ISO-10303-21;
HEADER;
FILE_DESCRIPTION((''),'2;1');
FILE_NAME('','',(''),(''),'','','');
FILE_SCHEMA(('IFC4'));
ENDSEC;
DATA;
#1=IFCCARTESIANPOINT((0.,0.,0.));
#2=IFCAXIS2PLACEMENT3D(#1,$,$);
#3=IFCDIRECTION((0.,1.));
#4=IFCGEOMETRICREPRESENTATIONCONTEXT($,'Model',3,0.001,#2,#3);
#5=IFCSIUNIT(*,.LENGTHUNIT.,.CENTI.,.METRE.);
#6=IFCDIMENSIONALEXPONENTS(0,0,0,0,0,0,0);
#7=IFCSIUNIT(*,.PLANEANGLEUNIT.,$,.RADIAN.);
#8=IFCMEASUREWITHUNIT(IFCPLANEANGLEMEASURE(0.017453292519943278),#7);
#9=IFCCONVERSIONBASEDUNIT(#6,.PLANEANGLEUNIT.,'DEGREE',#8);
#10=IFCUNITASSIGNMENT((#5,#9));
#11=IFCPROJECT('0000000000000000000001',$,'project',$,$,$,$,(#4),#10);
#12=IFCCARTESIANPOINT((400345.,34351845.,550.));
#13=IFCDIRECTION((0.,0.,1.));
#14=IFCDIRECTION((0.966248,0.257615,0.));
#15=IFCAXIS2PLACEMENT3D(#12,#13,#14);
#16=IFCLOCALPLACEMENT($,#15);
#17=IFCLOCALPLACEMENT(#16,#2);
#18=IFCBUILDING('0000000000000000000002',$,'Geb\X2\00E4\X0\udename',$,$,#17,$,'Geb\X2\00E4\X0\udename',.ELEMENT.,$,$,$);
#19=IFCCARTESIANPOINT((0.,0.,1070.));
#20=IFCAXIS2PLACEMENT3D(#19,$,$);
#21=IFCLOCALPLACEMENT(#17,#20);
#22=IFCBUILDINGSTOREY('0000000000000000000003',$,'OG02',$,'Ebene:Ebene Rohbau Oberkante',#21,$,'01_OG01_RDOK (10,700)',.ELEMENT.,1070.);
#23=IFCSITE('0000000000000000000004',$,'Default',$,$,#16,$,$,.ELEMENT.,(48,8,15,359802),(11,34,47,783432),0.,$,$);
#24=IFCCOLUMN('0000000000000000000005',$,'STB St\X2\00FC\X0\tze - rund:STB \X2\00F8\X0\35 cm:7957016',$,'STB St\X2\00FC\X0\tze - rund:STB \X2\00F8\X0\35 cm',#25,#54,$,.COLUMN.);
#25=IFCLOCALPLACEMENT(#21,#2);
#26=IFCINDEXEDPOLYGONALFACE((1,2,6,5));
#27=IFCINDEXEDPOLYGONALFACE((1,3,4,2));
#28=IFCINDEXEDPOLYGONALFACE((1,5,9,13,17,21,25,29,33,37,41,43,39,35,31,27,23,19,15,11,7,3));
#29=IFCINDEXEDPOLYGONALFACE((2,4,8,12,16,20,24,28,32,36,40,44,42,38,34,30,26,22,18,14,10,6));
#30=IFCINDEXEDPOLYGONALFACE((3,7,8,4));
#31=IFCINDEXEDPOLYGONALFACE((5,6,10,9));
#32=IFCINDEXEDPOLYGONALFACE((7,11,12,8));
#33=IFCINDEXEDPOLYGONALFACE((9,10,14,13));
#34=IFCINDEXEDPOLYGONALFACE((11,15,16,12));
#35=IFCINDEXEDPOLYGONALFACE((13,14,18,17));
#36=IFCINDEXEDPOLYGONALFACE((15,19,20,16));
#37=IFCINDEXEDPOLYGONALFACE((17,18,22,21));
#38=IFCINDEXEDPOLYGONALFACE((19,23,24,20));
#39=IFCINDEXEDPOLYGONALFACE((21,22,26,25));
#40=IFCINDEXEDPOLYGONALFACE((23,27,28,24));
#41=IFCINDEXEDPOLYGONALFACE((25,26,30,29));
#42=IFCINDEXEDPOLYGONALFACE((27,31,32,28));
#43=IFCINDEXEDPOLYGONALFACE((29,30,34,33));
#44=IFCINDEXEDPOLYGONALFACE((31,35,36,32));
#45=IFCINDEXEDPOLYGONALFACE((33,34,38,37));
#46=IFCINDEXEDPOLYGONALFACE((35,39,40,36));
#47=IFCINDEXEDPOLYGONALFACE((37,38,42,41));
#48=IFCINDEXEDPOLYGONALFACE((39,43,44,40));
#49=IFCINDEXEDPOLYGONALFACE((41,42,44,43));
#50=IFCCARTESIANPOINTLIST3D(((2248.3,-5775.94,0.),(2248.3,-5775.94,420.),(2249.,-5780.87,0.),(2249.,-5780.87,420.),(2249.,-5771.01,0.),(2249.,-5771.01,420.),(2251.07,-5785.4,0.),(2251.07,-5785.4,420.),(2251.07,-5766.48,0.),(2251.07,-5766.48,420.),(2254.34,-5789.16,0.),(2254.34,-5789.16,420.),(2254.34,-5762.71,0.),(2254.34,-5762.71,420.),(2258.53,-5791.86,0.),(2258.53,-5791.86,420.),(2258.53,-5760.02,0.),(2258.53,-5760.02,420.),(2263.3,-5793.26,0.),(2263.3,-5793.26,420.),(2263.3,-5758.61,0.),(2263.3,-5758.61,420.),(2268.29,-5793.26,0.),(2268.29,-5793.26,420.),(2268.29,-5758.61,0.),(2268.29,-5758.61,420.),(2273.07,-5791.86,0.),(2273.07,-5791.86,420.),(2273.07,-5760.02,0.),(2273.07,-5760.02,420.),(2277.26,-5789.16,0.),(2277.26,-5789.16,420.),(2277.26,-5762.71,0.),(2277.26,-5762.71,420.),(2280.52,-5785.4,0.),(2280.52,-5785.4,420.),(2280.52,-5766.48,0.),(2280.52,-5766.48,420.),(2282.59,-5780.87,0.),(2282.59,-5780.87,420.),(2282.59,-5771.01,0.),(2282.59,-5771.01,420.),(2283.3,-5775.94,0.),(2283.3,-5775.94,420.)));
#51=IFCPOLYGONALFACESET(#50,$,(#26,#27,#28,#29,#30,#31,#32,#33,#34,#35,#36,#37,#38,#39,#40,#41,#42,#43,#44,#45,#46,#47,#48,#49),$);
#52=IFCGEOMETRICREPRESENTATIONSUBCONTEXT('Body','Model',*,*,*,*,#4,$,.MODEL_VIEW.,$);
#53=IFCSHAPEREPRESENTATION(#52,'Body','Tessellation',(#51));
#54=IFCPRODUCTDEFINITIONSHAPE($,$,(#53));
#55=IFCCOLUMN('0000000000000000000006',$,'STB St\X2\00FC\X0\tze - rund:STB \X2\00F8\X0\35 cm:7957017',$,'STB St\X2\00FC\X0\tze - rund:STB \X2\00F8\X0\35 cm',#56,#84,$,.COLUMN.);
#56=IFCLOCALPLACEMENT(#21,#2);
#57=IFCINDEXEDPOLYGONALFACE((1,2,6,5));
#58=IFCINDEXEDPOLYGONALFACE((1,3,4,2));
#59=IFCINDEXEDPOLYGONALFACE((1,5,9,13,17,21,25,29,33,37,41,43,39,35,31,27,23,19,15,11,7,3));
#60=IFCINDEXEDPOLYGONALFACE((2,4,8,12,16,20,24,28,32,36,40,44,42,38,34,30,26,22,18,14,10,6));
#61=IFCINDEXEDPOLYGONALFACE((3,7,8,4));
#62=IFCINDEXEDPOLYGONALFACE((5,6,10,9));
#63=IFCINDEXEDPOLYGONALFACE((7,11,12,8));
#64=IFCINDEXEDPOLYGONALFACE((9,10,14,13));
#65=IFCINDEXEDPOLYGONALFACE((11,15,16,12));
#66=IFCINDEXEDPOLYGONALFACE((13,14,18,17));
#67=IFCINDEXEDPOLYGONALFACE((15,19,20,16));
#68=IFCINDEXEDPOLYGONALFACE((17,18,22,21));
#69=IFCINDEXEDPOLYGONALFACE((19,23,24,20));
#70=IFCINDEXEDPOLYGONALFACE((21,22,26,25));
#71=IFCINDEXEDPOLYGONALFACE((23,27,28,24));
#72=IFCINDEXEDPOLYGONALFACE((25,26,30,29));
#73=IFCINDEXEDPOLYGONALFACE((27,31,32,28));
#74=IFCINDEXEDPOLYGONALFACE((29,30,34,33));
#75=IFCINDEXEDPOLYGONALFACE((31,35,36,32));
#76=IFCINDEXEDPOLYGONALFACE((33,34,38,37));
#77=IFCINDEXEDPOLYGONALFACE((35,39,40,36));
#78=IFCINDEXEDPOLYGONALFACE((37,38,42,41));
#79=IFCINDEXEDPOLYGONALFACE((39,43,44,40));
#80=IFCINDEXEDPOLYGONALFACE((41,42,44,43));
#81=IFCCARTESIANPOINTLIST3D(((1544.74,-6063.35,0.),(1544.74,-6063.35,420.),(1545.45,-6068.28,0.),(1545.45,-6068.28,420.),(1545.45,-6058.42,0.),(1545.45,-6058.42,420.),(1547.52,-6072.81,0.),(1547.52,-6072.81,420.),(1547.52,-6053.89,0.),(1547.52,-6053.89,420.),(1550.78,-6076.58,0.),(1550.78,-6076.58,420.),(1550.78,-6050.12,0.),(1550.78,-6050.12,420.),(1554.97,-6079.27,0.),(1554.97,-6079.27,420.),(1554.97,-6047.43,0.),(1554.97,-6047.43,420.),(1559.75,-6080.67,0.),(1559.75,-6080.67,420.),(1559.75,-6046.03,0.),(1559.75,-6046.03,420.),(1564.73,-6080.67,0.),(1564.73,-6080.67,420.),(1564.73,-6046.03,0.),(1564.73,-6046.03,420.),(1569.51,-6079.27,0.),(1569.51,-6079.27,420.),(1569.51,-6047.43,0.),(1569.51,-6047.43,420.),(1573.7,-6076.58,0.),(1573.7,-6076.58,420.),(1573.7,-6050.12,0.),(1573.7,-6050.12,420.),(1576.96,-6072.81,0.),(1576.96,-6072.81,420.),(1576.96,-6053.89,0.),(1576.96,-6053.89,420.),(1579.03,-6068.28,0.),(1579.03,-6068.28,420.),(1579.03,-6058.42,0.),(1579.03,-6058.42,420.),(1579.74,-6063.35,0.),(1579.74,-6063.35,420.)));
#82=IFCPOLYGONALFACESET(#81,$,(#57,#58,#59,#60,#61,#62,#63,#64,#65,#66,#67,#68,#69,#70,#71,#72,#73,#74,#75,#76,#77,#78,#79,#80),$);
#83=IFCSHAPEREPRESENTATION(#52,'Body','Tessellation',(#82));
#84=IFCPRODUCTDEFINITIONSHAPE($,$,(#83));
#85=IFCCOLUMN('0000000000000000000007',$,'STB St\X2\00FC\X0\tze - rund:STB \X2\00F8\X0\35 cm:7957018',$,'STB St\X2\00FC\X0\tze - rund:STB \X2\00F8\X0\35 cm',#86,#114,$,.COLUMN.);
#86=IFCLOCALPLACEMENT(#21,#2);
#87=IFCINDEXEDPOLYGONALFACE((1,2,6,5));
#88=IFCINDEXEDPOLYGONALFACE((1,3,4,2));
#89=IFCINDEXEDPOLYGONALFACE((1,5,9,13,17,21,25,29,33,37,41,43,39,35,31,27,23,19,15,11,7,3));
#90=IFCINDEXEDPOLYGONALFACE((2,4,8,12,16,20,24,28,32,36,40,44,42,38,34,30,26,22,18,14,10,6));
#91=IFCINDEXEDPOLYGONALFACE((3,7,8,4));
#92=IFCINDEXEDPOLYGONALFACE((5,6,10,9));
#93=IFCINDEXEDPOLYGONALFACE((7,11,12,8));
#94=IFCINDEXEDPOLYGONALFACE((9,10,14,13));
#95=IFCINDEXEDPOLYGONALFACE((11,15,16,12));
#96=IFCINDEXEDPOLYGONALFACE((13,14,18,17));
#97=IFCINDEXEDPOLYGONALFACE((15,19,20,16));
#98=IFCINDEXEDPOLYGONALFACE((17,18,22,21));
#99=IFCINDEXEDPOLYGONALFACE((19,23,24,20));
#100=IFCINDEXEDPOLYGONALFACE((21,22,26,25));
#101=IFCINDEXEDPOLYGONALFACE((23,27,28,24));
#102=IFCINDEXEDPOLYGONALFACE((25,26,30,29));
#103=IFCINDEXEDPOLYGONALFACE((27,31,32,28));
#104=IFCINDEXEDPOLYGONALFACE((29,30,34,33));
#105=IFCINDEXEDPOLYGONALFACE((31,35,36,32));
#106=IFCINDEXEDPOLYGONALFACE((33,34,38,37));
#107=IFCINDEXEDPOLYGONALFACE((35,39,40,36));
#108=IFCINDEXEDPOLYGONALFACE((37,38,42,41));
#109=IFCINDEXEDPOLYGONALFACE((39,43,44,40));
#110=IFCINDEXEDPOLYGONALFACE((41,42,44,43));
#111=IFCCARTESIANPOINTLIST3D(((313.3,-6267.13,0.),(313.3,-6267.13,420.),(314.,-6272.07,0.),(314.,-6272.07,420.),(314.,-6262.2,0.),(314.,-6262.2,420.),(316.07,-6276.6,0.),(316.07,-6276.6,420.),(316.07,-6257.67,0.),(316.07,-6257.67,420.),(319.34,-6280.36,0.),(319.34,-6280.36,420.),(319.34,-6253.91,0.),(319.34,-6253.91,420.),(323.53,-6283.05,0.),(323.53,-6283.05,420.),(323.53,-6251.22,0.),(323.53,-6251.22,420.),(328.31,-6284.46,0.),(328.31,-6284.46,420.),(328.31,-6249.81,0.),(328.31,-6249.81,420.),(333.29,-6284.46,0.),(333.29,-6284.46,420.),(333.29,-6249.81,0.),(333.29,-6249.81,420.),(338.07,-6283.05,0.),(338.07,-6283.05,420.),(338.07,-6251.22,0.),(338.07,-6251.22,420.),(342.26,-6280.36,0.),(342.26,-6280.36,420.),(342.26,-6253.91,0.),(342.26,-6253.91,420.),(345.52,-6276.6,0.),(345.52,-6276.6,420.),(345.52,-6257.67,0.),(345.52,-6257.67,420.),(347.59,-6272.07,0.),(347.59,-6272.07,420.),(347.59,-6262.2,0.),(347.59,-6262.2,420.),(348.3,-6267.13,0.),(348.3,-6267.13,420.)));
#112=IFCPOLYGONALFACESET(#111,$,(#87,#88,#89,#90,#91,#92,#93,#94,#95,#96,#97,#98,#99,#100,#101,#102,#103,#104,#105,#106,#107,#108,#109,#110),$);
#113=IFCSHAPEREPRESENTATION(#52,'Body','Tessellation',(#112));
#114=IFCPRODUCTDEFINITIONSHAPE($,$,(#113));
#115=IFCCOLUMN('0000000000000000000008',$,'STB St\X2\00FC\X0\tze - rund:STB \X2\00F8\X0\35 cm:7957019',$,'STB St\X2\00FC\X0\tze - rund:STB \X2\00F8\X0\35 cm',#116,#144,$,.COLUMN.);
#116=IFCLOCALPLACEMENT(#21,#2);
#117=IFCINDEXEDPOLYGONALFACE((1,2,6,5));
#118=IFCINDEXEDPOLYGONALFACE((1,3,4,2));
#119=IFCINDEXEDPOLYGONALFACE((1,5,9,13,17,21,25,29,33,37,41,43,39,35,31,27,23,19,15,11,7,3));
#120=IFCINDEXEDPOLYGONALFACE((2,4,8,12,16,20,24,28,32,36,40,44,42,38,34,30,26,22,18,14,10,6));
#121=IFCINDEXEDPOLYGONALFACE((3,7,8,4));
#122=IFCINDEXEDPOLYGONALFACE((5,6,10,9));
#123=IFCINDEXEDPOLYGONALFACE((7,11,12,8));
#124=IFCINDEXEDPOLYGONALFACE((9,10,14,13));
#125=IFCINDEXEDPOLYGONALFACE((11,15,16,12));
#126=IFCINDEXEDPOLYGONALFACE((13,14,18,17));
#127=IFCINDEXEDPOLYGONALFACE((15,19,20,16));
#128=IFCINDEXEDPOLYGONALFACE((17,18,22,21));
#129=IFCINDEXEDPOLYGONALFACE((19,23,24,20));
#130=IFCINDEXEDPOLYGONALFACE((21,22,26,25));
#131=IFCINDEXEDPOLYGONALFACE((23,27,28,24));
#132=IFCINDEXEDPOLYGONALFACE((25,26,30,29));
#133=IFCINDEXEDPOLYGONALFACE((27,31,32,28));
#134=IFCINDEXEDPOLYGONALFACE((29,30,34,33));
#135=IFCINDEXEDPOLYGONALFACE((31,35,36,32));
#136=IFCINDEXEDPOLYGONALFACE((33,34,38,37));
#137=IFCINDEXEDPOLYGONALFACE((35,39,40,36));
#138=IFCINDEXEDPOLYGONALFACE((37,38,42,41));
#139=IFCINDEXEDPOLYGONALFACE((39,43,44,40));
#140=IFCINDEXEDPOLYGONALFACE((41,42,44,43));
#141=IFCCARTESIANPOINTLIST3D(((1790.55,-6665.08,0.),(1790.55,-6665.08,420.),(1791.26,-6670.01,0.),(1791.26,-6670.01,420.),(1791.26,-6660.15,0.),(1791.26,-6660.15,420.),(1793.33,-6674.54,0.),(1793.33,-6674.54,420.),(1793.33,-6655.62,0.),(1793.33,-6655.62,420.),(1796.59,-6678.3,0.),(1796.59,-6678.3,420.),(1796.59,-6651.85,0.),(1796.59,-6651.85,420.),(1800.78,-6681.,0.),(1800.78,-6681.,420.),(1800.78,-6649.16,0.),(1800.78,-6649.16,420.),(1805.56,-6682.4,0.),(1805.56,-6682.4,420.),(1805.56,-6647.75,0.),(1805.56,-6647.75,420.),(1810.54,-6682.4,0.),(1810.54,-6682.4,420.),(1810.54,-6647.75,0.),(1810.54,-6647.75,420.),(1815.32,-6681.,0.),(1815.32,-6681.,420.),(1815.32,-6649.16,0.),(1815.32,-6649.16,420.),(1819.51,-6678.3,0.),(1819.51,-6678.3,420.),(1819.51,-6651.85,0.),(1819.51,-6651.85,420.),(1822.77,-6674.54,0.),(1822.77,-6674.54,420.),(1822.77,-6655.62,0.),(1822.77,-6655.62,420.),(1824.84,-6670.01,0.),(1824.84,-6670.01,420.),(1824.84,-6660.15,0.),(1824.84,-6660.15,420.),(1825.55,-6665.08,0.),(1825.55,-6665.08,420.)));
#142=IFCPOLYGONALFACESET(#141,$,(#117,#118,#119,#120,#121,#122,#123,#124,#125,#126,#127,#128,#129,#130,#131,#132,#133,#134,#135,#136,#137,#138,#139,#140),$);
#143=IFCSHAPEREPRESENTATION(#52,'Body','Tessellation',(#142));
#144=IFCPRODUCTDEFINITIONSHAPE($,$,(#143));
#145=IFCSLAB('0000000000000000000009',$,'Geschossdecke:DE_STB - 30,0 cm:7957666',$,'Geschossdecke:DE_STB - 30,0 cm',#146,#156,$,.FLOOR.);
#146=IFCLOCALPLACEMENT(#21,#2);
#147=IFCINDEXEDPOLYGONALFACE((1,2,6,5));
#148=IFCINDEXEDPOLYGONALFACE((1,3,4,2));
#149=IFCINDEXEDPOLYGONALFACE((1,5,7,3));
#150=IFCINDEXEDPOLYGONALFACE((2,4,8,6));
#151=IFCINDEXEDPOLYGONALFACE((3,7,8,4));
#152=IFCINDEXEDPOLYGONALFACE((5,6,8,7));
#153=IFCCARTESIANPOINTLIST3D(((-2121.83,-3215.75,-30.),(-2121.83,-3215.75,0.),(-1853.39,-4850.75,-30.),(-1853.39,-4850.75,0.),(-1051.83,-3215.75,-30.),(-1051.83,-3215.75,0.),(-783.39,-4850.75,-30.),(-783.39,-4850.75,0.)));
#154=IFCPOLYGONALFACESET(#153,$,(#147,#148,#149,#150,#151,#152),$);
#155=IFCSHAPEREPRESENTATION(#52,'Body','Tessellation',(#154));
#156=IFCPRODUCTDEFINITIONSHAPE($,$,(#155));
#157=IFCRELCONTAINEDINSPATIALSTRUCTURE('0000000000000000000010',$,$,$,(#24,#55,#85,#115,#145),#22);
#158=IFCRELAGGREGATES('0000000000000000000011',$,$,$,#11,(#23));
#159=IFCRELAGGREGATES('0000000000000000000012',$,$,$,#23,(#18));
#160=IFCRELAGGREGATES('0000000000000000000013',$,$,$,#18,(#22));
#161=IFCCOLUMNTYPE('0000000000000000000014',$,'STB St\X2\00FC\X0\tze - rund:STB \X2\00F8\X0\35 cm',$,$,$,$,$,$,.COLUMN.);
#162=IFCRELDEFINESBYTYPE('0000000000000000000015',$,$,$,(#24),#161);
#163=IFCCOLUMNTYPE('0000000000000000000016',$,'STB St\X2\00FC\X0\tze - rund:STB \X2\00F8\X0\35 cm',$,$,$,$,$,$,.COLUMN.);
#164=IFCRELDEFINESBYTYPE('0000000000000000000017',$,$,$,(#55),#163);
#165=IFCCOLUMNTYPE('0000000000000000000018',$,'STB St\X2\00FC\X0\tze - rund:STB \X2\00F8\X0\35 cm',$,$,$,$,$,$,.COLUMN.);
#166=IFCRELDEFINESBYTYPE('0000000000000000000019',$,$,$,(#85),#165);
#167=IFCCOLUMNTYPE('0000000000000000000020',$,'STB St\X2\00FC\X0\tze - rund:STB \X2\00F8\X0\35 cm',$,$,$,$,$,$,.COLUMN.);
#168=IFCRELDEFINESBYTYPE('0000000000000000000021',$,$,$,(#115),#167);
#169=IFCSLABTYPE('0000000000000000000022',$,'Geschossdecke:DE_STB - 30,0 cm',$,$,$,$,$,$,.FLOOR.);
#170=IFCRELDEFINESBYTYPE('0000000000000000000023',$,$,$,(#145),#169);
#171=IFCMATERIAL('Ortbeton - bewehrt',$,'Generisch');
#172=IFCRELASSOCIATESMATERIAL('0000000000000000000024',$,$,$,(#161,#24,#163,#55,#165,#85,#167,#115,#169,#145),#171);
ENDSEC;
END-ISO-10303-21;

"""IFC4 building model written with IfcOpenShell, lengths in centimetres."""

from ifc_helpers import new_model, entity, si_unit, converted_unit, direction, frame, origin, place, context, subcontext, project, spatial, arc, indexed_curve, outline, extrude, source, transform, mapped, material, type_object, type_shapes, element, save


model = new_model("IFC4")

# Units and contexts
model_context = context("Model", 3, precision=0.001, world=origin(), true_north=direction((0.0, 1.0)))
body_context = subcontext(model_context, "Body", "Model", "MODEL_VIEW")
ifc_project = project(units=[si_unit("LENGTHUNIT", "METRE", prefix="CENTI"), converted_unit("PLANEANGLEUNIT", "DEGREE", entity("IfcPlaneAngleMeasure", 0.017453292519943278), si_unit("PLANEANGLEUNIT", "RADIAN"), dimensions=[0, 0, 0, 0, 0, 0, 0])], contexts=[model_context])

# Site, building, storey
site_placement = place(None, frame((400345.0, 34351845.0, 550.0), z_axis=(0.0, 0.0, 1.0), x_axis=(0.966248, 0.257615, 0.0)))
site = spatial("IfcSite", under=ifc_project, at=site_placement, Name="Default", CompositionType="ELEMENT", RefLatitude=(48, 8, 15, 359802), RefLongitude=(11, 34, 47, 783432), RefElevation=0.0)
building_placement = place(site_placement, origin())
building = spatial("IfcBuilding", under=site, at=building_placement, Name="Gebäudename", LongName="Gebäudename", CompositionType="ELEMENT")
storey_placement = place(building_placement, frame((0.0, 0.0, 1070.0)))
storey = spatial("IfcBuildingStorey", under=building, at=storey_placement, Name="OG02", ObjectType="Ebene:Ebene Rohbau Oberkante", LongName="01_OG01_RDOK (10,700)", CompositionType="ELEMENT", Elevation=1070.0)

# Columns
ifc_material = material(Name="Ortbeton - bewehrt", Category="Generisch")
column_type_1 = type_object("IfcColumnType", Name="STB Stütze - rund:STB ø35 cm", PredefinedType="COLUMN", material=ifc_material)
shared_shape_1 = source(origin(), body_context, "Body", "SweptSolid", [
    extrude(outline(indexed_curve([(-17.5, 0.0), (0.0, -17.5), (17.5, 0.0), (0.0, 17.5)], segments=[arc(1, 2, 3), arc(3, 4, 1)], self_intersect=False)), frame((2265.8, -5775.94, 1070.0)), (0.0, 0.0, 1.0), 420.0),
])
type_shapes(column_type_1, [shared_shape_1])
column_1_placement = place(storey_placement, frame((0.0, 0.0, -1070.0)))
element("IfcColumn", 1, at=column_1_placement, inside=storey, type_object=column_type_1, material=ifc_material, Name="STB Stütze - rund:STB ø35 cm:7957016", ObjectType="STB Stütze - rund:STB ø35 cm", PredefinedType="COLUMN", context=body_context, shape_type="MappedRepresentation", body=[
    mapped(shared_shape_1, transform((0.0, 0.0, 0.0), scale=1.0)),
])
column_type_2 = type_object("IfcColumnType", Name="STB Stütze - rund:STB ø35 cm", PredefinedType="COLUMN", material=ifc_material)
shared_shape_2 = source(origin(), body_context, "Body", "SweptSolid", [
    extrude(outline(indexed_curve([(-17.5, 0.0), (0.0, -17.5), (17.5, 0.0), (0.0, 17.5)], segments=[arc(1, 2, 3), arc(3, 4, 1)], self_intersect=False)), frame((1562.24, -6063.35, 1070.0)), (0.0, 0.0, 1.0), 420.0),
])
type_shapes(column_type_2, [shared_shape_2])
column_2_placement = place(storey_placement, frame((0.0, 0.0, -1070.0)))
element("IfcColumn", 2, at=column_2_placement, inside=storey, type_object=column_type_2, material=ifc_material, Name="STB Stütze - rund:STB ø35 cm:7957017", ObjectType="STB Stütze - rund:STB ø35 cm", PredefinedType="COLUMN", context=body_context, shape_type="MappedRepresentation", body=[
    mapped(shared_shape_2, transform((0.0, 0.0, 0.0), scale=1.0)),
])
column_type_3 = type_object("IfcColumnType", Name="STB Stütze - rund:STB ø35 cm", PredefinedType="COLUMN", material=ifc_material)
shared_shape_3 = source(origin(), body_context, "Body", "SweptSolid", [
    extrude(outline(indexed_curve([(-17.5, 0.0), (0.0, -17.5), (17.5, 0.0), (0.0, 17.5)], segments=[arc(1, 2, 3), arc(3, 4, 1)], self_intersect=False)), frame((330.8, -6267.13, 1070.0)), (0.0, 0.0, 1.0), 420.0),
])
type_shapes(column_type_3, [shared_shape_3])
column_3_placement = place(storey_placement, frame((0.0, 0.0, -1070.0)))
element("IfcColumn", 3, at=column_3_placement, inside=storey, type_object=column_type_3, material=ifc_material, Name="STB Stütze - rund:STB ø35 cm:7957018", ObjectType="STB Stütze - rund:STB ø35 cm", PredefinedType="COLUMN", context=body_context, shape_type="MappedRepresentation", body=[
    mapped(shared_shape_3, transform((0.0, 0.0, 0.0), scale=1.0)),
])
column_type_4 = type_object("IfcColumnType", Name="STB Stütze - rund:STB ø35 cm", PredefinedType="COLUMN", material=ifc_material)
shared_shape_4 = source(origin(), body_context, "Body", "SweptSolid", [
    extrude(outline(indexed_curve([(-17.5, 0.0), (0.0, -17.5), (17.5, 0.0), (0.0, 17.5)], segments=[arc(1, 2, 3), arc(3, 4, 1)], self_intersect=False)), frame((1808.05, -6665.08, 1070.0)), (0.0, 0.0, 1.0), 420.0),
])
type_shapes(column_type_4, [shared_shape_4])
column_4_placement = place(storey_placement, frame((0.0, 0.0, -1070.0)))
element("IfcColumn", 4, at=column_4_placement, inside=storey, type_object=column_type_4, material=ifc_material, Name="STB Stütze - rund:STB ø35 cm:7957019", ObjectType="STB Stütze - rund:STB ø35 cm", PredefinedType="COLUMN", context=body_context, shape_type="MappedRepresentation", body=[
    mapped(shared_shape_4, transform((0.0, 0.0, 0.0), scale=1.0)),
])

# Shared definitions
slab_type = type_object("IfcSlabType", Name="Geschossdecke:DE_STB - 30,0 cm", PredefinedType="FLOOR", material=ifc_material)

# Slab
slab_1_placement = place(storey_placement, origin())
element("IfcSlab", 5, at=slab_1_placement, inside=storey, type_object=slab_type, material=ifc_material, Name="Geschossdecke:DE_STB - 30,0 cm:7957666", ObjectType="Geschossdecke:DE_STB - 30,0 cm", PredefinedType="FLOOR", context=body_context, shape_type="SweptSolid", body=[
    extrude(outline(indexed_curve([(-669.22, -817.5), (400.78, -817.5), (669.22, 817.5), (-400.78, 817.5), (-669.22, -817.5)], self_intersect=False)), frame((-1452.61, -4033.25, 0.0), z_axis=(0.0, 0.0, -1.0), x_axis=(-1.0, 0.0, 0.0)), (0.0, 0.0, 1.0), 30.0),
])

save(model, "model.ifc")
